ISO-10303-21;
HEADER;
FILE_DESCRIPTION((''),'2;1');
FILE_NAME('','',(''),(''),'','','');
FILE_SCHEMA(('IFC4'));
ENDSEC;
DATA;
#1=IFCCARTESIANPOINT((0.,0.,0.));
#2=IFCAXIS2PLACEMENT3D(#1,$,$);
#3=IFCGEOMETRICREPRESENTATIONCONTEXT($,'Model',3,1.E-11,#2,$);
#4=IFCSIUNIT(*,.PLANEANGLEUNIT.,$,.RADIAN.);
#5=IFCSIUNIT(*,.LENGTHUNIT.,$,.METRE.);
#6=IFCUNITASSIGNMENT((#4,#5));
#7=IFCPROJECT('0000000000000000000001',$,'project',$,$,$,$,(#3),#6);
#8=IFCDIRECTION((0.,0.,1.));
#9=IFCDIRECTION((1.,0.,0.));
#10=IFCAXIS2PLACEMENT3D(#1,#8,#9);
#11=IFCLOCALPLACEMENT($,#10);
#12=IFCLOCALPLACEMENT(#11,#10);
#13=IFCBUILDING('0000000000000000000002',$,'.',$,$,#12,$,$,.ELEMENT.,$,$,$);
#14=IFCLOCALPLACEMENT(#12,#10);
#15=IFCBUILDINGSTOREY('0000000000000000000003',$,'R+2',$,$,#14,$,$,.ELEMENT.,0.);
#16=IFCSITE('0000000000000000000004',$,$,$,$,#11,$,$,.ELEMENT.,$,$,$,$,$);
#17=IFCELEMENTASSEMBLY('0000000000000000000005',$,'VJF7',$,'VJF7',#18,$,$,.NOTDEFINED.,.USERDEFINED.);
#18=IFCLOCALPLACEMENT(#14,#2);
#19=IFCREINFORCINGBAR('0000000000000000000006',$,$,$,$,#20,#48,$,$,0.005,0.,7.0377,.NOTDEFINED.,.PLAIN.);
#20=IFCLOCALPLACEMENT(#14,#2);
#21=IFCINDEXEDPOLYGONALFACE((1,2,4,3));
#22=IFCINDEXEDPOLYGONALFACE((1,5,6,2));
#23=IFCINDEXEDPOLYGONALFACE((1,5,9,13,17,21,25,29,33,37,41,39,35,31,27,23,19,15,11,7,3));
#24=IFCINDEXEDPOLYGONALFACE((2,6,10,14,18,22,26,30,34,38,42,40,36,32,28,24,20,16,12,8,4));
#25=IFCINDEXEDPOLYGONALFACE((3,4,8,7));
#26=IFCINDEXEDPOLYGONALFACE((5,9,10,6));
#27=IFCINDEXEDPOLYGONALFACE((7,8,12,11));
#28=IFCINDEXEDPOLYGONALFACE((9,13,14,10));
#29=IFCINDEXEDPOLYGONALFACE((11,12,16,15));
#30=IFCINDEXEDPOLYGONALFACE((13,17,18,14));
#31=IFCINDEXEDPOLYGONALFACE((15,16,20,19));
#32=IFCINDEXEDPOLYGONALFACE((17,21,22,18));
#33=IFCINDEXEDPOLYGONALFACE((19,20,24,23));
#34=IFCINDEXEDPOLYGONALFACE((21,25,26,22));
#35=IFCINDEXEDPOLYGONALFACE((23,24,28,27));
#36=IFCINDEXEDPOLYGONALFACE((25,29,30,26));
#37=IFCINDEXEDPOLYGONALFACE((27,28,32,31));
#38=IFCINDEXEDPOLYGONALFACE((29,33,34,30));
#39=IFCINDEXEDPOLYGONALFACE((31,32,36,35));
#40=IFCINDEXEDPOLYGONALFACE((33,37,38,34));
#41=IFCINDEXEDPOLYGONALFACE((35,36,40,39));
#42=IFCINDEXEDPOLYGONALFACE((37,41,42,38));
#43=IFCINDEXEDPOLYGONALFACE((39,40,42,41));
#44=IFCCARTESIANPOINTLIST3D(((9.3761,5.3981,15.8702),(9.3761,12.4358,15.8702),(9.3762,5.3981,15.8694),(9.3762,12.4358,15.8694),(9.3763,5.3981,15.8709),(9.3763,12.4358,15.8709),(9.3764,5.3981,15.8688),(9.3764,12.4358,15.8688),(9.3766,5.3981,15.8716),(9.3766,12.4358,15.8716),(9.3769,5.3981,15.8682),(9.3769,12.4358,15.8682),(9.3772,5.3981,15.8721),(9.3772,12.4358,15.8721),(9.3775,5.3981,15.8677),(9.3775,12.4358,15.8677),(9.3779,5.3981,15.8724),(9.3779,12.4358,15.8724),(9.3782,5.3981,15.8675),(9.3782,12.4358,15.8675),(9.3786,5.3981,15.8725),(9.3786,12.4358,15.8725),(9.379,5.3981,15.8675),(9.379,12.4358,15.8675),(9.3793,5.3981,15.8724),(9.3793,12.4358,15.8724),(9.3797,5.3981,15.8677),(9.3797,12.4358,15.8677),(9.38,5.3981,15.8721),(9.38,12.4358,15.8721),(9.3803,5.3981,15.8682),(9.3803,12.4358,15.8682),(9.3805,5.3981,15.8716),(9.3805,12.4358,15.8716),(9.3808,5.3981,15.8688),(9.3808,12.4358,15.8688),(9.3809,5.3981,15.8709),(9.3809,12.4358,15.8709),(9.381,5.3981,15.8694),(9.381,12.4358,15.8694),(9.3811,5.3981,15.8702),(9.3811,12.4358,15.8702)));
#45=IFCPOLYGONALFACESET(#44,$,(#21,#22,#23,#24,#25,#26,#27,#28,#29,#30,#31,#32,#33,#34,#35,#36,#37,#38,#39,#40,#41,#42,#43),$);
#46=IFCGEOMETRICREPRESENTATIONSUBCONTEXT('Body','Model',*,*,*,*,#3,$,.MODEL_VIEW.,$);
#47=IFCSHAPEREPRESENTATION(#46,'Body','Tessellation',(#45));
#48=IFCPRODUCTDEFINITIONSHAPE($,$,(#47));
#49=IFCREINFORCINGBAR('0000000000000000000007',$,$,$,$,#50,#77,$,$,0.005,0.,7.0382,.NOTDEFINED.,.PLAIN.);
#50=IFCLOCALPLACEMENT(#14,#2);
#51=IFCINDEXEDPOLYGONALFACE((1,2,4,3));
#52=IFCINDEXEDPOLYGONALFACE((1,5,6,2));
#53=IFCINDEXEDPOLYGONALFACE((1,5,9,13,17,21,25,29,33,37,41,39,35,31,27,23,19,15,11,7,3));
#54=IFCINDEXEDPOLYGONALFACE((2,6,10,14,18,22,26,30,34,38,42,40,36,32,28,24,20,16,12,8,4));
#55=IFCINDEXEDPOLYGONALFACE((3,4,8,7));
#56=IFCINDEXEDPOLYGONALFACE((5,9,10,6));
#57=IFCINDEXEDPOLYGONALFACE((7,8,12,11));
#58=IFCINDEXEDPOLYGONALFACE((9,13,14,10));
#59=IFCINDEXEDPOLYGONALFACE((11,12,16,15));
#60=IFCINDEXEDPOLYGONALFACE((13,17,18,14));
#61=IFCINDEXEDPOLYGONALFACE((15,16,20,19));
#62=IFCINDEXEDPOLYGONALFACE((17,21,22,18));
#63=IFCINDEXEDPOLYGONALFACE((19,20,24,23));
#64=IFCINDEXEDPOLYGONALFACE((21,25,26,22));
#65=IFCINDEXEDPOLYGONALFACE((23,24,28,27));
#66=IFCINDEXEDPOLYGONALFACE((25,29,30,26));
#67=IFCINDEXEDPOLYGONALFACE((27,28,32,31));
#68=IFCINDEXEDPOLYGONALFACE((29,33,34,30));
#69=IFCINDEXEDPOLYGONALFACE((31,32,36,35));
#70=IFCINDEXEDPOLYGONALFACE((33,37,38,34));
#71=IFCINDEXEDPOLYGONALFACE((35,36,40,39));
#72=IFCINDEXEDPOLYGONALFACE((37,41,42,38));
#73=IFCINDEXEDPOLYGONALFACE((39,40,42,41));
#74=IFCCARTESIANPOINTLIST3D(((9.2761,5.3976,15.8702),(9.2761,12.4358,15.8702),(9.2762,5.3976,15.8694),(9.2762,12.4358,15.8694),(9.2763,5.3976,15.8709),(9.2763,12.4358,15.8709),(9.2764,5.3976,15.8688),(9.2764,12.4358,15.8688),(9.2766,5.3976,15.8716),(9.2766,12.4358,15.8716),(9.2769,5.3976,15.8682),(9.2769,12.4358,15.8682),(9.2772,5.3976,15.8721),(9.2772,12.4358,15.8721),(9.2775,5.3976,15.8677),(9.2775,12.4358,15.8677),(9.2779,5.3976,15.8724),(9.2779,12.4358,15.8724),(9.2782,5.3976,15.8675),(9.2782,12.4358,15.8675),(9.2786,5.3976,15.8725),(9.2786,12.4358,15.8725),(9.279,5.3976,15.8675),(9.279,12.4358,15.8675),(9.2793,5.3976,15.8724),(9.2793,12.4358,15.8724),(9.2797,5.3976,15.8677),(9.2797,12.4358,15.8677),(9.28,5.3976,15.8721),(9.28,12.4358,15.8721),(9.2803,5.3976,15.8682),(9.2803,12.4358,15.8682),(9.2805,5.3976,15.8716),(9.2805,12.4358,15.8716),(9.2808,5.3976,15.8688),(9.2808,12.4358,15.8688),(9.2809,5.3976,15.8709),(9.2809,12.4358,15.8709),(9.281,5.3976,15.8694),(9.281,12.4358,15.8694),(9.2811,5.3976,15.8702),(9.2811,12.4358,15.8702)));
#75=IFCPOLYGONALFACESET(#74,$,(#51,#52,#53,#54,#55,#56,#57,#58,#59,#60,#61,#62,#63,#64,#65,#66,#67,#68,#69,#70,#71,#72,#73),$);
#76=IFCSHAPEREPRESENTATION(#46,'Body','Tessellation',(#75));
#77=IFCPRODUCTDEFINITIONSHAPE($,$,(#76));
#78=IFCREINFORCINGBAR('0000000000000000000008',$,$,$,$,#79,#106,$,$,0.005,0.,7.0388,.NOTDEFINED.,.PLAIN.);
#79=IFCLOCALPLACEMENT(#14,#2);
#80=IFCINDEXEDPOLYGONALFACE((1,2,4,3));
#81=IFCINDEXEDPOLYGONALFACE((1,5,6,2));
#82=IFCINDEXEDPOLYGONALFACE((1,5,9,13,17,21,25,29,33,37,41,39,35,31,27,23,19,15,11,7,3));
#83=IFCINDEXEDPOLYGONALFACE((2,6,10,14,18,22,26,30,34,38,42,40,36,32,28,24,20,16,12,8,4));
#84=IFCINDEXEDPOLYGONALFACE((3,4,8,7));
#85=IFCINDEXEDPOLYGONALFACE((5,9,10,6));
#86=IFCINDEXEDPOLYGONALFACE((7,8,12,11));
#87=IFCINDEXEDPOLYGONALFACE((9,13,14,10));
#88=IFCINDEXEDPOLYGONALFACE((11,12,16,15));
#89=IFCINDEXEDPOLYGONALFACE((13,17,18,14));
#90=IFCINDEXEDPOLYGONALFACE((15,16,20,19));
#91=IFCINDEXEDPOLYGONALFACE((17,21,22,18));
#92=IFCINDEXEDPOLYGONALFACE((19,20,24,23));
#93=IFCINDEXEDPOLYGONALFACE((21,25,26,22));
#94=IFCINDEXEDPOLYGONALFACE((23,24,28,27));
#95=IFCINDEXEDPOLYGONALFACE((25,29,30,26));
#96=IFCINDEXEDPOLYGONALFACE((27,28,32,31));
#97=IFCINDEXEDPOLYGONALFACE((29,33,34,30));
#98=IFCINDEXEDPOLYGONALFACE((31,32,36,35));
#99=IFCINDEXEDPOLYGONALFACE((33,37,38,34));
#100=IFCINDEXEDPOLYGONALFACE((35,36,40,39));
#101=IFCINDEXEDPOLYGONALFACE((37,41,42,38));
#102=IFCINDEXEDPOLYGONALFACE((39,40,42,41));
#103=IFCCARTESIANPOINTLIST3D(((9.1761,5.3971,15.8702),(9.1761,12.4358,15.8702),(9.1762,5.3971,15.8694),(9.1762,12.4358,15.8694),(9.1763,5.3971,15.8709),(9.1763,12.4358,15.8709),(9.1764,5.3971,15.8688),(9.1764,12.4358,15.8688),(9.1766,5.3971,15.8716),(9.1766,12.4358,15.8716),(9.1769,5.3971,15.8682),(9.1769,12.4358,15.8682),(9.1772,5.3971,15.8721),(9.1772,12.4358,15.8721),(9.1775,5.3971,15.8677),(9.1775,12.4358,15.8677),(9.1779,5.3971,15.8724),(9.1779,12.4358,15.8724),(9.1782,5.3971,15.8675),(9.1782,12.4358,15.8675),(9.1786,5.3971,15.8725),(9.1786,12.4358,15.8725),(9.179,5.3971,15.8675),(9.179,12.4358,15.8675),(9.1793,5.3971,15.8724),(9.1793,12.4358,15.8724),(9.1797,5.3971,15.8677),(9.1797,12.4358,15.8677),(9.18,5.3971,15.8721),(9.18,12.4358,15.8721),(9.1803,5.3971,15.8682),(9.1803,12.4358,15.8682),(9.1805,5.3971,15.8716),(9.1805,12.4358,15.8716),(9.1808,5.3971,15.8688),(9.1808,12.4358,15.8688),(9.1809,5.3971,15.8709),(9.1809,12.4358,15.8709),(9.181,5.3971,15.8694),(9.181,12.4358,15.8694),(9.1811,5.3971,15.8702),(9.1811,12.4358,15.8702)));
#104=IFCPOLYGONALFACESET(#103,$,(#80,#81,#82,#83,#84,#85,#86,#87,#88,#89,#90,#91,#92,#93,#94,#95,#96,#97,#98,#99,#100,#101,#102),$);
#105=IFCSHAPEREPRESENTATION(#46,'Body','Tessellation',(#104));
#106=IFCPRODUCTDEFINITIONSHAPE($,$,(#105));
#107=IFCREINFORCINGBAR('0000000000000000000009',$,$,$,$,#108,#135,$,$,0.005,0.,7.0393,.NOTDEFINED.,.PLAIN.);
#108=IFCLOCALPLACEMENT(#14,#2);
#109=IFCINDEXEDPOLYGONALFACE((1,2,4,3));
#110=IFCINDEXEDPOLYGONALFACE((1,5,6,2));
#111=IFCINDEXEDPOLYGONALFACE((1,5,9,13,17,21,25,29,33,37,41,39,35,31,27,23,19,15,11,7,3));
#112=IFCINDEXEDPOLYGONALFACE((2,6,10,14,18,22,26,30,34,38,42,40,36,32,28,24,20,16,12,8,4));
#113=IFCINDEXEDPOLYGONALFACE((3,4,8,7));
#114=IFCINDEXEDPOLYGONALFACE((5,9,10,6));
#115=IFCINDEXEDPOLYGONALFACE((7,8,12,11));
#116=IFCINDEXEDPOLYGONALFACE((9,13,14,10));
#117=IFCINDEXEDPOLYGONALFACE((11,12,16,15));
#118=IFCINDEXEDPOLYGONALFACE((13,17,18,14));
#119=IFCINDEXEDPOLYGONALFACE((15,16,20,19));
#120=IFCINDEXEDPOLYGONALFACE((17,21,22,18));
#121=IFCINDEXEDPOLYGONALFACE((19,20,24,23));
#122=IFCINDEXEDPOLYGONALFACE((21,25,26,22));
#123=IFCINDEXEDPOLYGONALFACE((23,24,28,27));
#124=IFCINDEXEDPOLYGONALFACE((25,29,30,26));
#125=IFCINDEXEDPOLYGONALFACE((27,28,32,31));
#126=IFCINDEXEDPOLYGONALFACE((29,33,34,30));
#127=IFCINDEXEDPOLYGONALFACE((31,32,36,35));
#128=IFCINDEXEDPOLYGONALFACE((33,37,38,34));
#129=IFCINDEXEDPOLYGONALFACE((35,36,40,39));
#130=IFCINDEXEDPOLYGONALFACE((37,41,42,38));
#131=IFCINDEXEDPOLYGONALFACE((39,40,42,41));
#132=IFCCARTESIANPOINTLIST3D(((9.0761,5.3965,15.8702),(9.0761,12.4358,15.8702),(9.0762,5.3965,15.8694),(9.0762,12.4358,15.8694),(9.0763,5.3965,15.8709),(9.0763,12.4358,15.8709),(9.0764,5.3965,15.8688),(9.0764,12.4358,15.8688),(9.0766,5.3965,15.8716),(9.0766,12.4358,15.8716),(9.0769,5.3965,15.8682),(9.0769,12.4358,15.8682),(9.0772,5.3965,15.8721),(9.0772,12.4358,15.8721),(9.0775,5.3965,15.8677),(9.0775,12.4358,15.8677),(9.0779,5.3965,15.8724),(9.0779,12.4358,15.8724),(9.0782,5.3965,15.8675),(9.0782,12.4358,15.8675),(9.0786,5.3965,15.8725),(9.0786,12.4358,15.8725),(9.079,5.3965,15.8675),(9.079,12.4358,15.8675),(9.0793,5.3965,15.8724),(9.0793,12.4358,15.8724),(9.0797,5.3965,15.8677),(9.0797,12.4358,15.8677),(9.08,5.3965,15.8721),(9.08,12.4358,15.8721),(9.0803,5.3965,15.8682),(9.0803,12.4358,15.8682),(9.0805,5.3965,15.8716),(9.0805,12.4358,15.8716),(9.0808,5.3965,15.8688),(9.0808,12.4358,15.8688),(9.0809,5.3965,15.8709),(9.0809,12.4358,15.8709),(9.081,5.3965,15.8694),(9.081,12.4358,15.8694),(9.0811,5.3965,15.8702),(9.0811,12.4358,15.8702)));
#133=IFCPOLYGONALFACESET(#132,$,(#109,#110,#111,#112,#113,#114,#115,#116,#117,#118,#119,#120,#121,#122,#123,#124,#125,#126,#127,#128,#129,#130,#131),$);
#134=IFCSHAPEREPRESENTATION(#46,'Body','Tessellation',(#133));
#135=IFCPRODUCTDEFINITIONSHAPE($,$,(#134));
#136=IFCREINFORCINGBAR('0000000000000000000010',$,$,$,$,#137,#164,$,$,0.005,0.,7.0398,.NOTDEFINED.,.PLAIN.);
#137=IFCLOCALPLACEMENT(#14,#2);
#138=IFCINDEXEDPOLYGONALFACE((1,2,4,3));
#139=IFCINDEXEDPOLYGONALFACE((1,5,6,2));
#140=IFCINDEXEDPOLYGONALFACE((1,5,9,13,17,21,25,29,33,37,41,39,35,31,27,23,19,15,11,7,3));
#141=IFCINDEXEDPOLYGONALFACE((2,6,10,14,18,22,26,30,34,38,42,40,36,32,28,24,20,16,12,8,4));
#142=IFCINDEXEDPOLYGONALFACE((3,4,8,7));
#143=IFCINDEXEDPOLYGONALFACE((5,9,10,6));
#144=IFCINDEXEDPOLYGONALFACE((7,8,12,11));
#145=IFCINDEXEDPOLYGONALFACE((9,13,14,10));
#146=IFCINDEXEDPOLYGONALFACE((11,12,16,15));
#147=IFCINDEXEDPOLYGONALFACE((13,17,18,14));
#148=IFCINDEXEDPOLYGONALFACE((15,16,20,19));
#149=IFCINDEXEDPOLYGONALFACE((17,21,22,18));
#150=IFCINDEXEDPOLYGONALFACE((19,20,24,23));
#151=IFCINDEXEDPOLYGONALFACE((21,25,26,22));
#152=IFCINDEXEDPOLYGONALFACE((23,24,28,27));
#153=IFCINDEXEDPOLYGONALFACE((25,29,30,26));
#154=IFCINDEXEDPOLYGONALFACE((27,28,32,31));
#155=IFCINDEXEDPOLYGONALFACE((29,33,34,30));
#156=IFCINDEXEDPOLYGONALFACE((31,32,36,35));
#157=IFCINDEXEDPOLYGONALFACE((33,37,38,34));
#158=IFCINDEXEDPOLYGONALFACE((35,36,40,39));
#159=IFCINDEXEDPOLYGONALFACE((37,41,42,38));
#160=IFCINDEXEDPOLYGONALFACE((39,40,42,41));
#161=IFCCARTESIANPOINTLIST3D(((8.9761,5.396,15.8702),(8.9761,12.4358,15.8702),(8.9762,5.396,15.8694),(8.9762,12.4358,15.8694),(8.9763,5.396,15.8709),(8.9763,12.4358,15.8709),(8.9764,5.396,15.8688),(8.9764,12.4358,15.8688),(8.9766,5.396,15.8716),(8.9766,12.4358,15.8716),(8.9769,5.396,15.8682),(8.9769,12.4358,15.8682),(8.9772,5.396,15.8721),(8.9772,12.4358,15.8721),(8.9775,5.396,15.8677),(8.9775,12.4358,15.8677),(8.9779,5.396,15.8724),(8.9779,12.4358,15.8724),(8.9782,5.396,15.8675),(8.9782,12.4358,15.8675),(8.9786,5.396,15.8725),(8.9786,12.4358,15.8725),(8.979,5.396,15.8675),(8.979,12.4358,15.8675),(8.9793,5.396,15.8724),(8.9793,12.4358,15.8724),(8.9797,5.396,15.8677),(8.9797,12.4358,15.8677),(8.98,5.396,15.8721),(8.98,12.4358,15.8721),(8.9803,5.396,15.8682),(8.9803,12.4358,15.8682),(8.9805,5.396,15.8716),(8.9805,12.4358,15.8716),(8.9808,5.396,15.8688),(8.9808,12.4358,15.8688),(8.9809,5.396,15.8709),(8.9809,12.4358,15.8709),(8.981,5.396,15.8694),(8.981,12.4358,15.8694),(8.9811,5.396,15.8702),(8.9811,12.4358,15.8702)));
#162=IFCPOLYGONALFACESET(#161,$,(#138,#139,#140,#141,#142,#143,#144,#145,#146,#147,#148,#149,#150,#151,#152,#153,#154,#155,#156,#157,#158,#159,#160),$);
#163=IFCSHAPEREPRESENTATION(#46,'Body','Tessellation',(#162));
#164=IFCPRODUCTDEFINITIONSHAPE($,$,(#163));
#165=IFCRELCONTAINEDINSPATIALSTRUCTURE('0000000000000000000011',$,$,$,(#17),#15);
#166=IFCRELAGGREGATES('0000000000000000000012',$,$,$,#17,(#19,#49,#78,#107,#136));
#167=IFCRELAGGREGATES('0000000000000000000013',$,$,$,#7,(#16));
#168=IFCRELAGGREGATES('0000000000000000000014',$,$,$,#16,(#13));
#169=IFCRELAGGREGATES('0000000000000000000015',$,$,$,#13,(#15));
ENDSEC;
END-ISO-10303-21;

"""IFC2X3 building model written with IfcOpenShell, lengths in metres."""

from ifc_helpers import new_model, entity, si_unit, origin, origin_with_axes, place, context, subcontext, project, spatial, shape, element, aggregate, save


model = new_model("IFC2X3")

# Units and contexts
model_context = context("Model", 3, precision=1e-11, world=origin())
body_context = subcontext(model_context, "Body", "Model", "MODEL_VIEW")
ifc_project = project(units=[si_unit("PLANEANGLEUNIT", "RADIAN"), si_unit("LENGTHUNIT", "METRE")], contexts=[model_context])

# Site, building, storey
site_placement = place(None, origin_with_axes())
site = spatial("IfcSite", under=ifc_project, at=site_placement, CompositionType="ELEMENT")
building_placement = place(site_placement, origin_with_axes())
building = spatial("IfcBuilding", under=site, at=building_placement, Name=".", CompositionType="ELEMENT")
storey_placement = place(building_placement, origin_with_axes())
storey = spatial("IfcBuildingStorey", under=building, at=storey_placement, Name="R+2", CompositionType="ELEMENT", Elevation=0.0)

# Element assembly, reinforcing bars
assembly_1_placement = place(storey_placement, origin_with_axes())
assembly_1 = element("IfcElementAssembly", 1, at=assembly_1_placement, inside=storey, Name="VJF7", ObjectType="VJF7", AssemblyPlace="NOTDEFINED", PredefinedType="USERDEFINED")
reinforcing_bar_1_placement = place(assembly_1_placement, origin_with_axes())
reinforcing_bar_1 = element("IfcReinforcingBar", 2, at=reinforcing_bar_1_placement, BarLength=7.0377, BarRole="NOTDEFINED", BarSurface="PLAIN", CrossSectionArea=0.0, NominalDiameter=0.005, shapes=[
    shape(body_context, "Body", "AdvancedSweptSolid", [entity("IfcSweptDiskSolid", entity("IfcPolyline", [entity("IfcCartesianPoint", [9.3786, 5.3981, 15.87]), entity("IfcCartesianPoint", [9.3786, 12.4358, 15.87])]), 0.0025, None, 0.0, 7.0377)]),
    shape(body_context, "Body", "AdvancedSweptSolid", [entity("IfcSweptDiskSolid", entity("IfcPolyline", [entity("IfcCartesianPoint", [9.3786, 5.3981, 15.87]), entity("IfcCartesianPoint", [9.3786, 12.4358, 15.87])]), 0.0025, None, 0.0, 7.0377)]),
])
reinforcing_bar_2_placement = place(assembly_1_placement, origin_with_axes())
reinforcing_bar_2 = element("IfcReinforcingBar", 3, at=reinforcing_bar_2_placement, BarLength=7.0382, BarRole="NOTDEFINED", BarSurface="PLAIN", CrossSectionArea=0.0, NominalDiameter=0.005, shapes=[
    shape(body_context, "Body", "AdvancedSweptSolid", [entity("IfcSweptDiskSolid", entity("IfcPolyline", [entity("IfcCartesianPoint", [9.2786, 5.3976, 15.87]), entity("IfcCartesianPoint", [9.2786, 12.4358, 15.87])]), 0.0025, None, 0.0, 7.0382)]),
    shape(body_context, "Body", "AdvancedSweptSolid", [entity("IfcSweptDiskSolid", entity("IfcPolyline", [entity("IfcCartesianPoint", [9.2786, 5.3976, 15.87]), entity("IfcCartesianPoint", [9.2786, 12.4358, 15.87])]), 0.0025, None, 0.0, 7.0382)]),
])
reinforcing_bar_3_placement = place(assembly_1_placement, origin_with_axes())
reinforcing_bar_3 = element("IfcReinforcingBar", 4, at=reinforcing_bar_3_placement, BarLength=7.0388, BarRole="NOTDEFINED", BarSurface="PLAIN", CrossSectionArea=0.0, NominalDiameter=0.005, shapes=[
    shape(body_context, "Body", "AdvancedSweptSolid", [entity("IfcSweptDiskSolid", entity("IfcPolyline", [entity("IfcCartesianPoint", [9.1786, 5.3971, 15.87]), entity("IfcCartesianPoint", [9.1786, 12.4358, 15.87])]), 0.0025, None, 0.0, 7.0388)]),
    shape(body_context, "Body", "AdvancedSweptSolid", [entity("IfcSweptDiskSolid", entity("IfcPolyline", [entity("IfcCartesianPoint", [9.1786, 5.3971, 15.87]), entity("IfcCartesianPoint", [9.1786, 12.4358, 15.87])]), 0.0025, None, 0.0, 7.0388)]),
])
reinforcing_bar_4_placement = place(assembly_1_placement, origin_with_axes())
reinforcing_bar_4 = element("IfcReinforcingBar", 5, at=reinforcing_bar_4_placement, BarLength=7.0393, BarRole="NOTDEFINED", BarSurface="PLAIN", CrossSectionArea=0.0, NominalDiameter=0.005, shapes=[
    shape(body_context, "Body", "AdvancedSweptSolid", [entity("IfcSweptDiskSolid", entity("IfcPolyline", [entity("IfcCartesianPoint", [9.0786, 5.3965, 15.87]), entity("IfcCartesianPoint", [9.0786, 12.4358, 15.87])]), 0.0025, None, 0.0, 7.0393)]),
    shape(body_context, "Body", "AdvancedSweptSolid", [entity("IfcSweptDiskSolid", entity("IfcPolyline", [entity("IfcCartesianPoint", [9.0786, 5.3965, 15.87]), entity("IfcCartesianPoint", [9.0786, 12.4358, 15.87])]), 0.0025, None, 0.0, 7.0393)]),
])
reinforcing_bar_5_placement = place(assembly_1_placement, origin_with_axes())
reinforcing_bar_5 = element("IfcReinforcingBar", 6, at=reinforcing_bar_5_placement, BarLength=7.0398, BarRole="NOTDEFINED", BarSurface="PLAIN", CrossSectionArea=0.0, NominalDiameter=0.005, shapes=[
    shape(body_context, "Body", "AdvancedSweptSolid", [entity("IfcSweptDiskSolid", entity("IfcPolyline", [entity("IfcCartesianPoint", [8.9786, 5.396, 15.87]), entity("IfcCartesianPoint", [8.9786, 12.4358, 15.87])]), 0.0025, None, 0.0, 7.0398)]),
    shape(body_context, "Body", "AdvancedSweptSolid", [entity("IfcSweptDiskSolid", entity("IfcPolyline", [entity("IfcCartesianPoint", [8.9786, 5.396, 15.87]), entity("IfcCartesianPoint", [8.9786, 12.4358, 15.87])]), 0.0025, None, 0.0, 7.0398)]),
])
aggregate(assembly_1, [reinforcing_bar_1, reinforcing_bar_2, reinforcing_bar_3, reinforcing_bar_4, reinforcing_bar_5])

save(model, "model.ifc")
